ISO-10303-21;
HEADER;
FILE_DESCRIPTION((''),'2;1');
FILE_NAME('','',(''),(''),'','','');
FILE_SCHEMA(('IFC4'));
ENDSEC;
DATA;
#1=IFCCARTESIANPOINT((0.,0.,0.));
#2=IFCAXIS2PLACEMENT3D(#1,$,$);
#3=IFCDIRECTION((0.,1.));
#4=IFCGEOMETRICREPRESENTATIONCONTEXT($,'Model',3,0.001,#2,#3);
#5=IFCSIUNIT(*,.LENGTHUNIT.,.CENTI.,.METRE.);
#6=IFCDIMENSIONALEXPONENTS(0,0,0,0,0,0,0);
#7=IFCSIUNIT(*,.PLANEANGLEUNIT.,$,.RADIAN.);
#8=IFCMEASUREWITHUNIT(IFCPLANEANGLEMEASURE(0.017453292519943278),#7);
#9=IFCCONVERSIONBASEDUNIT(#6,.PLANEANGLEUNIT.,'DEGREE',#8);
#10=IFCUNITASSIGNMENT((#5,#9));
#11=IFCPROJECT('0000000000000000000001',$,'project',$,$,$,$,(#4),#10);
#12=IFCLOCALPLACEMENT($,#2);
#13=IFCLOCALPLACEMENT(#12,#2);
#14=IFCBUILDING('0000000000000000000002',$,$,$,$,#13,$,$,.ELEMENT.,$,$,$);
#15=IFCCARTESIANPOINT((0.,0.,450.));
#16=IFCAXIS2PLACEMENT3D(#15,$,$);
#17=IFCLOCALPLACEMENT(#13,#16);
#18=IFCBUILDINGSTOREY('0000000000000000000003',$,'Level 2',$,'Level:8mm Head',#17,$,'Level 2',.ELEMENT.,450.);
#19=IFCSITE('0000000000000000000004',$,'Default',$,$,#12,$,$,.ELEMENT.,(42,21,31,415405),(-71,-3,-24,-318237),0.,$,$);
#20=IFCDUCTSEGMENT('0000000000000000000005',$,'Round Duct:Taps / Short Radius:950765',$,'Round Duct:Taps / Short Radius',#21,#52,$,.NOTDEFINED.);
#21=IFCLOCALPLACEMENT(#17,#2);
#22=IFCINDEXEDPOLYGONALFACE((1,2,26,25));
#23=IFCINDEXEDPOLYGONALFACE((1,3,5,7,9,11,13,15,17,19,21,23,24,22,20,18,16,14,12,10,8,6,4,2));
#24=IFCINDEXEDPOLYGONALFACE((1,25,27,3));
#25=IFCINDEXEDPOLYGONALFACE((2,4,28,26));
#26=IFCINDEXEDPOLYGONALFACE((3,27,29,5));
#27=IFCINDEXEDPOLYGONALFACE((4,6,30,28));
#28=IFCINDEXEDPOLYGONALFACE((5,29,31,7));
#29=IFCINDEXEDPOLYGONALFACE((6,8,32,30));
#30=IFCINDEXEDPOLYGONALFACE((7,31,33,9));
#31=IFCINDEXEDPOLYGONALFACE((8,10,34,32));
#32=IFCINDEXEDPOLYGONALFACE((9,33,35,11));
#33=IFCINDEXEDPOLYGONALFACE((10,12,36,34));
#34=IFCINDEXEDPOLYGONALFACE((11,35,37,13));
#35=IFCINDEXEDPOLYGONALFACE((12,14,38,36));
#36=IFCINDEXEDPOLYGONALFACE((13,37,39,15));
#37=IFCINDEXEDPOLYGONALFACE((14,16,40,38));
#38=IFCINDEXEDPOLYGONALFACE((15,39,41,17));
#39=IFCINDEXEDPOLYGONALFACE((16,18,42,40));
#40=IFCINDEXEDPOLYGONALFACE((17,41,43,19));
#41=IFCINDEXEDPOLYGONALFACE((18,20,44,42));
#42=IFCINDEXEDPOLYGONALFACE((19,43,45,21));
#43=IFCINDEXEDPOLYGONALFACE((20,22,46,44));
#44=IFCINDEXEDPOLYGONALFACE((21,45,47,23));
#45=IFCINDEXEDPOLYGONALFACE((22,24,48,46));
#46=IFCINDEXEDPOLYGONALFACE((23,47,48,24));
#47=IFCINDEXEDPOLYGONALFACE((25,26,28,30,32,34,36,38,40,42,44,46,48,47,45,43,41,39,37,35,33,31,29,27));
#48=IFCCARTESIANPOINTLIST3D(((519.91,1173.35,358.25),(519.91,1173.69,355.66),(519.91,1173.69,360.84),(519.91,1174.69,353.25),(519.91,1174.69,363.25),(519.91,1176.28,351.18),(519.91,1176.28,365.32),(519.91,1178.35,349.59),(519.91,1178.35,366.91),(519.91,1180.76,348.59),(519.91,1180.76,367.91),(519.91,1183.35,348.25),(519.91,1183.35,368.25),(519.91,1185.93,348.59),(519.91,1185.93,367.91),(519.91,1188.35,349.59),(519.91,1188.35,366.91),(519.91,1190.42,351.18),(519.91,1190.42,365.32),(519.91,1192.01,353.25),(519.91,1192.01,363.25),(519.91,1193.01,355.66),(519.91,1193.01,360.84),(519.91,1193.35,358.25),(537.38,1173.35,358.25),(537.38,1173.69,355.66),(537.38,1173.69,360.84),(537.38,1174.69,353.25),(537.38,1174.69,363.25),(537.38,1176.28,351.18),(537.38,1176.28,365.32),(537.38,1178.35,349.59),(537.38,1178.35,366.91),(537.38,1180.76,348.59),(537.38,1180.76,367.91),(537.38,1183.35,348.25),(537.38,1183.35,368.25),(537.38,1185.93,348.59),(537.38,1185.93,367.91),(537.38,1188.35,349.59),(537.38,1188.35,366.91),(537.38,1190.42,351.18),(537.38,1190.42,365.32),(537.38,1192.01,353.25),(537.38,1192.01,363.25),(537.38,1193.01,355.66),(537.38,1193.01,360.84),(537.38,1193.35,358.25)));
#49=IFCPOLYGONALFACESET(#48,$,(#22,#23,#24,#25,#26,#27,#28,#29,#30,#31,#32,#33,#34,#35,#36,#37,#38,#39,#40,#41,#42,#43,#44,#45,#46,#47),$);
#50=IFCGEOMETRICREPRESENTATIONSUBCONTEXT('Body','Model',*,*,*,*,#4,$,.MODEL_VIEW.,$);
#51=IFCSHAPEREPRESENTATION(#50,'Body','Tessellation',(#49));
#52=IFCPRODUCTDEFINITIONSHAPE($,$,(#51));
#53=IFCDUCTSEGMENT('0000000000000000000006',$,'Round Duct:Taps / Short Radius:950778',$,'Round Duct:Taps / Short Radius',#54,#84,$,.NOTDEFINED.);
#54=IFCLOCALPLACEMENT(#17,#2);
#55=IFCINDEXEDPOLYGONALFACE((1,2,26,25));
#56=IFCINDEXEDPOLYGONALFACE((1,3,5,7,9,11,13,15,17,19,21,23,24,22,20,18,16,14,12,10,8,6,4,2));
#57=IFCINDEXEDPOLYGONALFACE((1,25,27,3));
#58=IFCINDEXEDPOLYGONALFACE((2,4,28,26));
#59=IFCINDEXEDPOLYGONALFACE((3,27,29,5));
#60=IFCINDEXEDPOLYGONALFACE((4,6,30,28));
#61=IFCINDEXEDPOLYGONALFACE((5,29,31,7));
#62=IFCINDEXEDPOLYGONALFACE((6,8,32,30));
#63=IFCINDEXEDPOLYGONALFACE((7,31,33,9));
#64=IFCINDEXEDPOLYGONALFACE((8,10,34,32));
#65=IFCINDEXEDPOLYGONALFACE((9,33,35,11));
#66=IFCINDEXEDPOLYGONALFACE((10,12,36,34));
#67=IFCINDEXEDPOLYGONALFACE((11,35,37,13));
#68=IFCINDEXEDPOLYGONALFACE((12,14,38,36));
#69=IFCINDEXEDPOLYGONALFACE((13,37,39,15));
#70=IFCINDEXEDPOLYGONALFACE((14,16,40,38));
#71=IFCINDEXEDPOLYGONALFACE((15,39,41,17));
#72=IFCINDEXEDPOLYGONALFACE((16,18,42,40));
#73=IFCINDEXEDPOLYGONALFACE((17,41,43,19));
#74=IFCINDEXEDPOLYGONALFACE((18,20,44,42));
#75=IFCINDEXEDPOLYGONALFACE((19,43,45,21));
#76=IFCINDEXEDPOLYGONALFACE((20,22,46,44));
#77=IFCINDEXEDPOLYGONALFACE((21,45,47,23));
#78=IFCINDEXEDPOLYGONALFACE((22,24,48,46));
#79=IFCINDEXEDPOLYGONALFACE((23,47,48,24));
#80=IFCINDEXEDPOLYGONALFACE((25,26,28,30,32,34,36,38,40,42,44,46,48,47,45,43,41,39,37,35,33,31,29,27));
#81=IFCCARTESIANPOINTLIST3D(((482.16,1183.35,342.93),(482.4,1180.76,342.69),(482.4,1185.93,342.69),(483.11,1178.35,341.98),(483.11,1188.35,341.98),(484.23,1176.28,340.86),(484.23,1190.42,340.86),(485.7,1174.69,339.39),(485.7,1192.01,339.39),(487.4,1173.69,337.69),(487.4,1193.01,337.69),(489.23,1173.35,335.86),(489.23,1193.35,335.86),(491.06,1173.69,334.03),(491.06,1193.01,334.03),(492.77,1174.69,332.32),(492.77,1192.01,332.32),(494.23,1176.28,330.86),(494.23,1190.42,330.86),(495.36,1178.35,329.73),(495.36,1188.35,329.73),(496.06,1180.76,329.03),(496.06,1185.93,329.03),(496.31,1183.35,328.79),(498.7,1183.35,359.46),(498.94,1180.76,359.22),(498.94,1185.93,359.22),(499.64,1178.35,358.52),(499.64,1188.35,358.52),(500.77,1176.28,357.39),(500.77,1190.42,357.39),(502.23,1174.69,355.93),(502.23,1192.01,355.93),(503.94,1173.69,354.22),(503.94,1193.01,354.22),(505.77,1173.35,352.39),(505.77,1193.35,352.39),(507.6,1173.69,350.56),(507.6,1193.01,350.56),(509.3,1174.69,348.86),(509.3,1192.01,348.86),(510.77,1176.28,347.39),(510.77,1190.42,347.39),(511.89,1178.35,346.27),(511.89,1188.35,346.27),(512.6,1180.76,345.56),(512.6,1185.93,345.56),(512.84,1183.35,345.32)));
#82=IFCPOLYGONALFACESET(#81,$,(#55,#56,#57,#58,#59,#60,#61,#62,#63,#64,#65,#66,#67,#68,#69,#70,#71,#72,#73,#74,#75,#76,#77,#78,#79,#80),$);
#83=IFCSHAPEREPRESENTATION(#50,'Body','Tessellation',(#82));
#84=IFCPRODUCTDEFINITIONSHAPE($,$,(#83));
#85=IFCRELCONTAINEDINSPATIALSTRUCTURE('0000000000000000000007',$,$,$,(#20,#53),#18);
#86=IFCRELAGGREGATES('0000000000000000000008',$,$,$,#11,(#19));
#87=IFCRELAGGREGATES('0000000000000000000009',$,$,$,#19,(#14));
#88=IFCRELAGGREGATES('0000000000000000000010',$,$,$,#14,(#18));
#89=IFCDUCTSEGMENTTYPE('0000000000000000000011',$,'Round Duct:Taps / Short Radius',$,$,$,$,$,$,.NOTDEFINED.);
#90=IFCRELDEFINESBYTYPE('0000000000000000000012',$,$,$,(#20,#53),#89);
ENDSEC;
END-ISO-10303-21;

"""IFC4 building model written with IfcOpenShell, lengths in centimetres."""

from ifc_helpers import new_model, entity, si_unit, converted_unit, direction, frame, origin, place, context, subcontext, project, spatial, arc, indexed_curve, outline, extrude, type_object, element, save


model = new_model("IFC4")

# Units and contexts
model_context = context("Model", 3, precision=0.001, world=origin(), true_north=direction((0.0, 1.0)))
body_context = subcontext(model_context, "Body", "Model", "MODEL_VIEW")
ifc_project = project(units=[si_unit("LENGTHUNIT", "METRE", prefix="CENTI"), converted_unit("PLANEANGLEUNIT", "DEGREE", entity("IfcPlaneAngleMeasure", 0.017453292519943278), si_unit("PLANEANGLEUNIT", "RADIAN"), dimensions=[0, 0, 0, 0, 0, 0, 0])], contexts=[model_context])

# Site, building, storey
site_placement = place(None, origin())
site = spatial("IfcSite", under=ifc_project, at=site_placement, Name="Default", CompositionType="ELEMENT", RefLatitude=(42, 21, 31, 415405), RefLongitude=(-71, -3, -24, -318237), RefElevation=0.0)
building_placement = place(site_placement, origin())
building = spatial("IfcBuilding", under=site, at=building_placement, CompositionType="ELEMENT")
storey_placement = place(building_placement, frame((0.0, 0.0, 450.0)))
storey = spatial("IfcBuildingStorey", under=building, at=storey_placement, Name="Level 2", ObjectType="Level:8mm Head", LongName="Level 2", CompositionType="ELEMENT", Elevation=450.0)

# Duct segments
duct_segment_type_1 = type_object("IfcDuctSegmentType", Name="Round Duct:Taps / Short Radius", PredefinedType="NOTDEFINED")
duct_segment_1_placement = place(storey_placement, origin())
element("IfcDuctSegment", 1, at=duct_segment_1_placement, inside=storey, type_object=duct_segment_type_1, Name="Round Duct:Taps / Short Radius:950765", ObjectType="Round Duct:Taps / Short Radius", PredefinedType="NOTDEFINED", context=body_context, shape_type="SweptSolid", body=[
    extrude(outline(indexed_curve([(10.0, 0.0), (7.07, 7.07), (0.0, 10.0), (-7.07, 7.07), (-10.0, 0.0), (-7.07, -7.07), (0.0, -10.0), (7.07, -7.07)], segments=[arc(1, 2, 3), arc(3, 4, 5), arc(5, 6, 7), arc(7, 8, 1)], self_intersect=False)), frame((519.91, 1183.35, 358.25), z_axis=(1.0, 0.0, 0.0), x_axis=(0.0, -1.0, 0.0)), (0.0, 0.0, 1.0), 17.47),
])
duct_segment_2_placement = place(storey_placement, origin())
element("IfcDuctSegment", 2, at=duct_segment_2_placement, inside=storey, type_object=duct_segment_type_1, Name="Round Duct:Taps / Short Radius:950778", ObjectType="Round Duct:Taps / Short Radius", PredefinedType="NOTDEFINED", context=body_context, shape_type="SweptSolid", body=[
    extrude(outline(indexed_curve([(10.0, 0.0), (7.07, 7.07), (0.0, 10.0), (-7.07, 7.07), (-10.0, 0.0), (-7.07, -7.07), (0.0, -10.0), (7.07, -7.07)], segments=[arc(1, 2, 3), arc(3, 4, 5), arc(5, 6, 7), arc(7, 8, 1)], self_intersect=False)), frame((489.23, 1183.35, 335.86), z_axis=(0.707107, 0.0, 0.707107), x_axis=(0.0, -1.0, 0.0)), (0.0, 0.0, 1.0), 23.38),
])

save(model, "model.ifc")
